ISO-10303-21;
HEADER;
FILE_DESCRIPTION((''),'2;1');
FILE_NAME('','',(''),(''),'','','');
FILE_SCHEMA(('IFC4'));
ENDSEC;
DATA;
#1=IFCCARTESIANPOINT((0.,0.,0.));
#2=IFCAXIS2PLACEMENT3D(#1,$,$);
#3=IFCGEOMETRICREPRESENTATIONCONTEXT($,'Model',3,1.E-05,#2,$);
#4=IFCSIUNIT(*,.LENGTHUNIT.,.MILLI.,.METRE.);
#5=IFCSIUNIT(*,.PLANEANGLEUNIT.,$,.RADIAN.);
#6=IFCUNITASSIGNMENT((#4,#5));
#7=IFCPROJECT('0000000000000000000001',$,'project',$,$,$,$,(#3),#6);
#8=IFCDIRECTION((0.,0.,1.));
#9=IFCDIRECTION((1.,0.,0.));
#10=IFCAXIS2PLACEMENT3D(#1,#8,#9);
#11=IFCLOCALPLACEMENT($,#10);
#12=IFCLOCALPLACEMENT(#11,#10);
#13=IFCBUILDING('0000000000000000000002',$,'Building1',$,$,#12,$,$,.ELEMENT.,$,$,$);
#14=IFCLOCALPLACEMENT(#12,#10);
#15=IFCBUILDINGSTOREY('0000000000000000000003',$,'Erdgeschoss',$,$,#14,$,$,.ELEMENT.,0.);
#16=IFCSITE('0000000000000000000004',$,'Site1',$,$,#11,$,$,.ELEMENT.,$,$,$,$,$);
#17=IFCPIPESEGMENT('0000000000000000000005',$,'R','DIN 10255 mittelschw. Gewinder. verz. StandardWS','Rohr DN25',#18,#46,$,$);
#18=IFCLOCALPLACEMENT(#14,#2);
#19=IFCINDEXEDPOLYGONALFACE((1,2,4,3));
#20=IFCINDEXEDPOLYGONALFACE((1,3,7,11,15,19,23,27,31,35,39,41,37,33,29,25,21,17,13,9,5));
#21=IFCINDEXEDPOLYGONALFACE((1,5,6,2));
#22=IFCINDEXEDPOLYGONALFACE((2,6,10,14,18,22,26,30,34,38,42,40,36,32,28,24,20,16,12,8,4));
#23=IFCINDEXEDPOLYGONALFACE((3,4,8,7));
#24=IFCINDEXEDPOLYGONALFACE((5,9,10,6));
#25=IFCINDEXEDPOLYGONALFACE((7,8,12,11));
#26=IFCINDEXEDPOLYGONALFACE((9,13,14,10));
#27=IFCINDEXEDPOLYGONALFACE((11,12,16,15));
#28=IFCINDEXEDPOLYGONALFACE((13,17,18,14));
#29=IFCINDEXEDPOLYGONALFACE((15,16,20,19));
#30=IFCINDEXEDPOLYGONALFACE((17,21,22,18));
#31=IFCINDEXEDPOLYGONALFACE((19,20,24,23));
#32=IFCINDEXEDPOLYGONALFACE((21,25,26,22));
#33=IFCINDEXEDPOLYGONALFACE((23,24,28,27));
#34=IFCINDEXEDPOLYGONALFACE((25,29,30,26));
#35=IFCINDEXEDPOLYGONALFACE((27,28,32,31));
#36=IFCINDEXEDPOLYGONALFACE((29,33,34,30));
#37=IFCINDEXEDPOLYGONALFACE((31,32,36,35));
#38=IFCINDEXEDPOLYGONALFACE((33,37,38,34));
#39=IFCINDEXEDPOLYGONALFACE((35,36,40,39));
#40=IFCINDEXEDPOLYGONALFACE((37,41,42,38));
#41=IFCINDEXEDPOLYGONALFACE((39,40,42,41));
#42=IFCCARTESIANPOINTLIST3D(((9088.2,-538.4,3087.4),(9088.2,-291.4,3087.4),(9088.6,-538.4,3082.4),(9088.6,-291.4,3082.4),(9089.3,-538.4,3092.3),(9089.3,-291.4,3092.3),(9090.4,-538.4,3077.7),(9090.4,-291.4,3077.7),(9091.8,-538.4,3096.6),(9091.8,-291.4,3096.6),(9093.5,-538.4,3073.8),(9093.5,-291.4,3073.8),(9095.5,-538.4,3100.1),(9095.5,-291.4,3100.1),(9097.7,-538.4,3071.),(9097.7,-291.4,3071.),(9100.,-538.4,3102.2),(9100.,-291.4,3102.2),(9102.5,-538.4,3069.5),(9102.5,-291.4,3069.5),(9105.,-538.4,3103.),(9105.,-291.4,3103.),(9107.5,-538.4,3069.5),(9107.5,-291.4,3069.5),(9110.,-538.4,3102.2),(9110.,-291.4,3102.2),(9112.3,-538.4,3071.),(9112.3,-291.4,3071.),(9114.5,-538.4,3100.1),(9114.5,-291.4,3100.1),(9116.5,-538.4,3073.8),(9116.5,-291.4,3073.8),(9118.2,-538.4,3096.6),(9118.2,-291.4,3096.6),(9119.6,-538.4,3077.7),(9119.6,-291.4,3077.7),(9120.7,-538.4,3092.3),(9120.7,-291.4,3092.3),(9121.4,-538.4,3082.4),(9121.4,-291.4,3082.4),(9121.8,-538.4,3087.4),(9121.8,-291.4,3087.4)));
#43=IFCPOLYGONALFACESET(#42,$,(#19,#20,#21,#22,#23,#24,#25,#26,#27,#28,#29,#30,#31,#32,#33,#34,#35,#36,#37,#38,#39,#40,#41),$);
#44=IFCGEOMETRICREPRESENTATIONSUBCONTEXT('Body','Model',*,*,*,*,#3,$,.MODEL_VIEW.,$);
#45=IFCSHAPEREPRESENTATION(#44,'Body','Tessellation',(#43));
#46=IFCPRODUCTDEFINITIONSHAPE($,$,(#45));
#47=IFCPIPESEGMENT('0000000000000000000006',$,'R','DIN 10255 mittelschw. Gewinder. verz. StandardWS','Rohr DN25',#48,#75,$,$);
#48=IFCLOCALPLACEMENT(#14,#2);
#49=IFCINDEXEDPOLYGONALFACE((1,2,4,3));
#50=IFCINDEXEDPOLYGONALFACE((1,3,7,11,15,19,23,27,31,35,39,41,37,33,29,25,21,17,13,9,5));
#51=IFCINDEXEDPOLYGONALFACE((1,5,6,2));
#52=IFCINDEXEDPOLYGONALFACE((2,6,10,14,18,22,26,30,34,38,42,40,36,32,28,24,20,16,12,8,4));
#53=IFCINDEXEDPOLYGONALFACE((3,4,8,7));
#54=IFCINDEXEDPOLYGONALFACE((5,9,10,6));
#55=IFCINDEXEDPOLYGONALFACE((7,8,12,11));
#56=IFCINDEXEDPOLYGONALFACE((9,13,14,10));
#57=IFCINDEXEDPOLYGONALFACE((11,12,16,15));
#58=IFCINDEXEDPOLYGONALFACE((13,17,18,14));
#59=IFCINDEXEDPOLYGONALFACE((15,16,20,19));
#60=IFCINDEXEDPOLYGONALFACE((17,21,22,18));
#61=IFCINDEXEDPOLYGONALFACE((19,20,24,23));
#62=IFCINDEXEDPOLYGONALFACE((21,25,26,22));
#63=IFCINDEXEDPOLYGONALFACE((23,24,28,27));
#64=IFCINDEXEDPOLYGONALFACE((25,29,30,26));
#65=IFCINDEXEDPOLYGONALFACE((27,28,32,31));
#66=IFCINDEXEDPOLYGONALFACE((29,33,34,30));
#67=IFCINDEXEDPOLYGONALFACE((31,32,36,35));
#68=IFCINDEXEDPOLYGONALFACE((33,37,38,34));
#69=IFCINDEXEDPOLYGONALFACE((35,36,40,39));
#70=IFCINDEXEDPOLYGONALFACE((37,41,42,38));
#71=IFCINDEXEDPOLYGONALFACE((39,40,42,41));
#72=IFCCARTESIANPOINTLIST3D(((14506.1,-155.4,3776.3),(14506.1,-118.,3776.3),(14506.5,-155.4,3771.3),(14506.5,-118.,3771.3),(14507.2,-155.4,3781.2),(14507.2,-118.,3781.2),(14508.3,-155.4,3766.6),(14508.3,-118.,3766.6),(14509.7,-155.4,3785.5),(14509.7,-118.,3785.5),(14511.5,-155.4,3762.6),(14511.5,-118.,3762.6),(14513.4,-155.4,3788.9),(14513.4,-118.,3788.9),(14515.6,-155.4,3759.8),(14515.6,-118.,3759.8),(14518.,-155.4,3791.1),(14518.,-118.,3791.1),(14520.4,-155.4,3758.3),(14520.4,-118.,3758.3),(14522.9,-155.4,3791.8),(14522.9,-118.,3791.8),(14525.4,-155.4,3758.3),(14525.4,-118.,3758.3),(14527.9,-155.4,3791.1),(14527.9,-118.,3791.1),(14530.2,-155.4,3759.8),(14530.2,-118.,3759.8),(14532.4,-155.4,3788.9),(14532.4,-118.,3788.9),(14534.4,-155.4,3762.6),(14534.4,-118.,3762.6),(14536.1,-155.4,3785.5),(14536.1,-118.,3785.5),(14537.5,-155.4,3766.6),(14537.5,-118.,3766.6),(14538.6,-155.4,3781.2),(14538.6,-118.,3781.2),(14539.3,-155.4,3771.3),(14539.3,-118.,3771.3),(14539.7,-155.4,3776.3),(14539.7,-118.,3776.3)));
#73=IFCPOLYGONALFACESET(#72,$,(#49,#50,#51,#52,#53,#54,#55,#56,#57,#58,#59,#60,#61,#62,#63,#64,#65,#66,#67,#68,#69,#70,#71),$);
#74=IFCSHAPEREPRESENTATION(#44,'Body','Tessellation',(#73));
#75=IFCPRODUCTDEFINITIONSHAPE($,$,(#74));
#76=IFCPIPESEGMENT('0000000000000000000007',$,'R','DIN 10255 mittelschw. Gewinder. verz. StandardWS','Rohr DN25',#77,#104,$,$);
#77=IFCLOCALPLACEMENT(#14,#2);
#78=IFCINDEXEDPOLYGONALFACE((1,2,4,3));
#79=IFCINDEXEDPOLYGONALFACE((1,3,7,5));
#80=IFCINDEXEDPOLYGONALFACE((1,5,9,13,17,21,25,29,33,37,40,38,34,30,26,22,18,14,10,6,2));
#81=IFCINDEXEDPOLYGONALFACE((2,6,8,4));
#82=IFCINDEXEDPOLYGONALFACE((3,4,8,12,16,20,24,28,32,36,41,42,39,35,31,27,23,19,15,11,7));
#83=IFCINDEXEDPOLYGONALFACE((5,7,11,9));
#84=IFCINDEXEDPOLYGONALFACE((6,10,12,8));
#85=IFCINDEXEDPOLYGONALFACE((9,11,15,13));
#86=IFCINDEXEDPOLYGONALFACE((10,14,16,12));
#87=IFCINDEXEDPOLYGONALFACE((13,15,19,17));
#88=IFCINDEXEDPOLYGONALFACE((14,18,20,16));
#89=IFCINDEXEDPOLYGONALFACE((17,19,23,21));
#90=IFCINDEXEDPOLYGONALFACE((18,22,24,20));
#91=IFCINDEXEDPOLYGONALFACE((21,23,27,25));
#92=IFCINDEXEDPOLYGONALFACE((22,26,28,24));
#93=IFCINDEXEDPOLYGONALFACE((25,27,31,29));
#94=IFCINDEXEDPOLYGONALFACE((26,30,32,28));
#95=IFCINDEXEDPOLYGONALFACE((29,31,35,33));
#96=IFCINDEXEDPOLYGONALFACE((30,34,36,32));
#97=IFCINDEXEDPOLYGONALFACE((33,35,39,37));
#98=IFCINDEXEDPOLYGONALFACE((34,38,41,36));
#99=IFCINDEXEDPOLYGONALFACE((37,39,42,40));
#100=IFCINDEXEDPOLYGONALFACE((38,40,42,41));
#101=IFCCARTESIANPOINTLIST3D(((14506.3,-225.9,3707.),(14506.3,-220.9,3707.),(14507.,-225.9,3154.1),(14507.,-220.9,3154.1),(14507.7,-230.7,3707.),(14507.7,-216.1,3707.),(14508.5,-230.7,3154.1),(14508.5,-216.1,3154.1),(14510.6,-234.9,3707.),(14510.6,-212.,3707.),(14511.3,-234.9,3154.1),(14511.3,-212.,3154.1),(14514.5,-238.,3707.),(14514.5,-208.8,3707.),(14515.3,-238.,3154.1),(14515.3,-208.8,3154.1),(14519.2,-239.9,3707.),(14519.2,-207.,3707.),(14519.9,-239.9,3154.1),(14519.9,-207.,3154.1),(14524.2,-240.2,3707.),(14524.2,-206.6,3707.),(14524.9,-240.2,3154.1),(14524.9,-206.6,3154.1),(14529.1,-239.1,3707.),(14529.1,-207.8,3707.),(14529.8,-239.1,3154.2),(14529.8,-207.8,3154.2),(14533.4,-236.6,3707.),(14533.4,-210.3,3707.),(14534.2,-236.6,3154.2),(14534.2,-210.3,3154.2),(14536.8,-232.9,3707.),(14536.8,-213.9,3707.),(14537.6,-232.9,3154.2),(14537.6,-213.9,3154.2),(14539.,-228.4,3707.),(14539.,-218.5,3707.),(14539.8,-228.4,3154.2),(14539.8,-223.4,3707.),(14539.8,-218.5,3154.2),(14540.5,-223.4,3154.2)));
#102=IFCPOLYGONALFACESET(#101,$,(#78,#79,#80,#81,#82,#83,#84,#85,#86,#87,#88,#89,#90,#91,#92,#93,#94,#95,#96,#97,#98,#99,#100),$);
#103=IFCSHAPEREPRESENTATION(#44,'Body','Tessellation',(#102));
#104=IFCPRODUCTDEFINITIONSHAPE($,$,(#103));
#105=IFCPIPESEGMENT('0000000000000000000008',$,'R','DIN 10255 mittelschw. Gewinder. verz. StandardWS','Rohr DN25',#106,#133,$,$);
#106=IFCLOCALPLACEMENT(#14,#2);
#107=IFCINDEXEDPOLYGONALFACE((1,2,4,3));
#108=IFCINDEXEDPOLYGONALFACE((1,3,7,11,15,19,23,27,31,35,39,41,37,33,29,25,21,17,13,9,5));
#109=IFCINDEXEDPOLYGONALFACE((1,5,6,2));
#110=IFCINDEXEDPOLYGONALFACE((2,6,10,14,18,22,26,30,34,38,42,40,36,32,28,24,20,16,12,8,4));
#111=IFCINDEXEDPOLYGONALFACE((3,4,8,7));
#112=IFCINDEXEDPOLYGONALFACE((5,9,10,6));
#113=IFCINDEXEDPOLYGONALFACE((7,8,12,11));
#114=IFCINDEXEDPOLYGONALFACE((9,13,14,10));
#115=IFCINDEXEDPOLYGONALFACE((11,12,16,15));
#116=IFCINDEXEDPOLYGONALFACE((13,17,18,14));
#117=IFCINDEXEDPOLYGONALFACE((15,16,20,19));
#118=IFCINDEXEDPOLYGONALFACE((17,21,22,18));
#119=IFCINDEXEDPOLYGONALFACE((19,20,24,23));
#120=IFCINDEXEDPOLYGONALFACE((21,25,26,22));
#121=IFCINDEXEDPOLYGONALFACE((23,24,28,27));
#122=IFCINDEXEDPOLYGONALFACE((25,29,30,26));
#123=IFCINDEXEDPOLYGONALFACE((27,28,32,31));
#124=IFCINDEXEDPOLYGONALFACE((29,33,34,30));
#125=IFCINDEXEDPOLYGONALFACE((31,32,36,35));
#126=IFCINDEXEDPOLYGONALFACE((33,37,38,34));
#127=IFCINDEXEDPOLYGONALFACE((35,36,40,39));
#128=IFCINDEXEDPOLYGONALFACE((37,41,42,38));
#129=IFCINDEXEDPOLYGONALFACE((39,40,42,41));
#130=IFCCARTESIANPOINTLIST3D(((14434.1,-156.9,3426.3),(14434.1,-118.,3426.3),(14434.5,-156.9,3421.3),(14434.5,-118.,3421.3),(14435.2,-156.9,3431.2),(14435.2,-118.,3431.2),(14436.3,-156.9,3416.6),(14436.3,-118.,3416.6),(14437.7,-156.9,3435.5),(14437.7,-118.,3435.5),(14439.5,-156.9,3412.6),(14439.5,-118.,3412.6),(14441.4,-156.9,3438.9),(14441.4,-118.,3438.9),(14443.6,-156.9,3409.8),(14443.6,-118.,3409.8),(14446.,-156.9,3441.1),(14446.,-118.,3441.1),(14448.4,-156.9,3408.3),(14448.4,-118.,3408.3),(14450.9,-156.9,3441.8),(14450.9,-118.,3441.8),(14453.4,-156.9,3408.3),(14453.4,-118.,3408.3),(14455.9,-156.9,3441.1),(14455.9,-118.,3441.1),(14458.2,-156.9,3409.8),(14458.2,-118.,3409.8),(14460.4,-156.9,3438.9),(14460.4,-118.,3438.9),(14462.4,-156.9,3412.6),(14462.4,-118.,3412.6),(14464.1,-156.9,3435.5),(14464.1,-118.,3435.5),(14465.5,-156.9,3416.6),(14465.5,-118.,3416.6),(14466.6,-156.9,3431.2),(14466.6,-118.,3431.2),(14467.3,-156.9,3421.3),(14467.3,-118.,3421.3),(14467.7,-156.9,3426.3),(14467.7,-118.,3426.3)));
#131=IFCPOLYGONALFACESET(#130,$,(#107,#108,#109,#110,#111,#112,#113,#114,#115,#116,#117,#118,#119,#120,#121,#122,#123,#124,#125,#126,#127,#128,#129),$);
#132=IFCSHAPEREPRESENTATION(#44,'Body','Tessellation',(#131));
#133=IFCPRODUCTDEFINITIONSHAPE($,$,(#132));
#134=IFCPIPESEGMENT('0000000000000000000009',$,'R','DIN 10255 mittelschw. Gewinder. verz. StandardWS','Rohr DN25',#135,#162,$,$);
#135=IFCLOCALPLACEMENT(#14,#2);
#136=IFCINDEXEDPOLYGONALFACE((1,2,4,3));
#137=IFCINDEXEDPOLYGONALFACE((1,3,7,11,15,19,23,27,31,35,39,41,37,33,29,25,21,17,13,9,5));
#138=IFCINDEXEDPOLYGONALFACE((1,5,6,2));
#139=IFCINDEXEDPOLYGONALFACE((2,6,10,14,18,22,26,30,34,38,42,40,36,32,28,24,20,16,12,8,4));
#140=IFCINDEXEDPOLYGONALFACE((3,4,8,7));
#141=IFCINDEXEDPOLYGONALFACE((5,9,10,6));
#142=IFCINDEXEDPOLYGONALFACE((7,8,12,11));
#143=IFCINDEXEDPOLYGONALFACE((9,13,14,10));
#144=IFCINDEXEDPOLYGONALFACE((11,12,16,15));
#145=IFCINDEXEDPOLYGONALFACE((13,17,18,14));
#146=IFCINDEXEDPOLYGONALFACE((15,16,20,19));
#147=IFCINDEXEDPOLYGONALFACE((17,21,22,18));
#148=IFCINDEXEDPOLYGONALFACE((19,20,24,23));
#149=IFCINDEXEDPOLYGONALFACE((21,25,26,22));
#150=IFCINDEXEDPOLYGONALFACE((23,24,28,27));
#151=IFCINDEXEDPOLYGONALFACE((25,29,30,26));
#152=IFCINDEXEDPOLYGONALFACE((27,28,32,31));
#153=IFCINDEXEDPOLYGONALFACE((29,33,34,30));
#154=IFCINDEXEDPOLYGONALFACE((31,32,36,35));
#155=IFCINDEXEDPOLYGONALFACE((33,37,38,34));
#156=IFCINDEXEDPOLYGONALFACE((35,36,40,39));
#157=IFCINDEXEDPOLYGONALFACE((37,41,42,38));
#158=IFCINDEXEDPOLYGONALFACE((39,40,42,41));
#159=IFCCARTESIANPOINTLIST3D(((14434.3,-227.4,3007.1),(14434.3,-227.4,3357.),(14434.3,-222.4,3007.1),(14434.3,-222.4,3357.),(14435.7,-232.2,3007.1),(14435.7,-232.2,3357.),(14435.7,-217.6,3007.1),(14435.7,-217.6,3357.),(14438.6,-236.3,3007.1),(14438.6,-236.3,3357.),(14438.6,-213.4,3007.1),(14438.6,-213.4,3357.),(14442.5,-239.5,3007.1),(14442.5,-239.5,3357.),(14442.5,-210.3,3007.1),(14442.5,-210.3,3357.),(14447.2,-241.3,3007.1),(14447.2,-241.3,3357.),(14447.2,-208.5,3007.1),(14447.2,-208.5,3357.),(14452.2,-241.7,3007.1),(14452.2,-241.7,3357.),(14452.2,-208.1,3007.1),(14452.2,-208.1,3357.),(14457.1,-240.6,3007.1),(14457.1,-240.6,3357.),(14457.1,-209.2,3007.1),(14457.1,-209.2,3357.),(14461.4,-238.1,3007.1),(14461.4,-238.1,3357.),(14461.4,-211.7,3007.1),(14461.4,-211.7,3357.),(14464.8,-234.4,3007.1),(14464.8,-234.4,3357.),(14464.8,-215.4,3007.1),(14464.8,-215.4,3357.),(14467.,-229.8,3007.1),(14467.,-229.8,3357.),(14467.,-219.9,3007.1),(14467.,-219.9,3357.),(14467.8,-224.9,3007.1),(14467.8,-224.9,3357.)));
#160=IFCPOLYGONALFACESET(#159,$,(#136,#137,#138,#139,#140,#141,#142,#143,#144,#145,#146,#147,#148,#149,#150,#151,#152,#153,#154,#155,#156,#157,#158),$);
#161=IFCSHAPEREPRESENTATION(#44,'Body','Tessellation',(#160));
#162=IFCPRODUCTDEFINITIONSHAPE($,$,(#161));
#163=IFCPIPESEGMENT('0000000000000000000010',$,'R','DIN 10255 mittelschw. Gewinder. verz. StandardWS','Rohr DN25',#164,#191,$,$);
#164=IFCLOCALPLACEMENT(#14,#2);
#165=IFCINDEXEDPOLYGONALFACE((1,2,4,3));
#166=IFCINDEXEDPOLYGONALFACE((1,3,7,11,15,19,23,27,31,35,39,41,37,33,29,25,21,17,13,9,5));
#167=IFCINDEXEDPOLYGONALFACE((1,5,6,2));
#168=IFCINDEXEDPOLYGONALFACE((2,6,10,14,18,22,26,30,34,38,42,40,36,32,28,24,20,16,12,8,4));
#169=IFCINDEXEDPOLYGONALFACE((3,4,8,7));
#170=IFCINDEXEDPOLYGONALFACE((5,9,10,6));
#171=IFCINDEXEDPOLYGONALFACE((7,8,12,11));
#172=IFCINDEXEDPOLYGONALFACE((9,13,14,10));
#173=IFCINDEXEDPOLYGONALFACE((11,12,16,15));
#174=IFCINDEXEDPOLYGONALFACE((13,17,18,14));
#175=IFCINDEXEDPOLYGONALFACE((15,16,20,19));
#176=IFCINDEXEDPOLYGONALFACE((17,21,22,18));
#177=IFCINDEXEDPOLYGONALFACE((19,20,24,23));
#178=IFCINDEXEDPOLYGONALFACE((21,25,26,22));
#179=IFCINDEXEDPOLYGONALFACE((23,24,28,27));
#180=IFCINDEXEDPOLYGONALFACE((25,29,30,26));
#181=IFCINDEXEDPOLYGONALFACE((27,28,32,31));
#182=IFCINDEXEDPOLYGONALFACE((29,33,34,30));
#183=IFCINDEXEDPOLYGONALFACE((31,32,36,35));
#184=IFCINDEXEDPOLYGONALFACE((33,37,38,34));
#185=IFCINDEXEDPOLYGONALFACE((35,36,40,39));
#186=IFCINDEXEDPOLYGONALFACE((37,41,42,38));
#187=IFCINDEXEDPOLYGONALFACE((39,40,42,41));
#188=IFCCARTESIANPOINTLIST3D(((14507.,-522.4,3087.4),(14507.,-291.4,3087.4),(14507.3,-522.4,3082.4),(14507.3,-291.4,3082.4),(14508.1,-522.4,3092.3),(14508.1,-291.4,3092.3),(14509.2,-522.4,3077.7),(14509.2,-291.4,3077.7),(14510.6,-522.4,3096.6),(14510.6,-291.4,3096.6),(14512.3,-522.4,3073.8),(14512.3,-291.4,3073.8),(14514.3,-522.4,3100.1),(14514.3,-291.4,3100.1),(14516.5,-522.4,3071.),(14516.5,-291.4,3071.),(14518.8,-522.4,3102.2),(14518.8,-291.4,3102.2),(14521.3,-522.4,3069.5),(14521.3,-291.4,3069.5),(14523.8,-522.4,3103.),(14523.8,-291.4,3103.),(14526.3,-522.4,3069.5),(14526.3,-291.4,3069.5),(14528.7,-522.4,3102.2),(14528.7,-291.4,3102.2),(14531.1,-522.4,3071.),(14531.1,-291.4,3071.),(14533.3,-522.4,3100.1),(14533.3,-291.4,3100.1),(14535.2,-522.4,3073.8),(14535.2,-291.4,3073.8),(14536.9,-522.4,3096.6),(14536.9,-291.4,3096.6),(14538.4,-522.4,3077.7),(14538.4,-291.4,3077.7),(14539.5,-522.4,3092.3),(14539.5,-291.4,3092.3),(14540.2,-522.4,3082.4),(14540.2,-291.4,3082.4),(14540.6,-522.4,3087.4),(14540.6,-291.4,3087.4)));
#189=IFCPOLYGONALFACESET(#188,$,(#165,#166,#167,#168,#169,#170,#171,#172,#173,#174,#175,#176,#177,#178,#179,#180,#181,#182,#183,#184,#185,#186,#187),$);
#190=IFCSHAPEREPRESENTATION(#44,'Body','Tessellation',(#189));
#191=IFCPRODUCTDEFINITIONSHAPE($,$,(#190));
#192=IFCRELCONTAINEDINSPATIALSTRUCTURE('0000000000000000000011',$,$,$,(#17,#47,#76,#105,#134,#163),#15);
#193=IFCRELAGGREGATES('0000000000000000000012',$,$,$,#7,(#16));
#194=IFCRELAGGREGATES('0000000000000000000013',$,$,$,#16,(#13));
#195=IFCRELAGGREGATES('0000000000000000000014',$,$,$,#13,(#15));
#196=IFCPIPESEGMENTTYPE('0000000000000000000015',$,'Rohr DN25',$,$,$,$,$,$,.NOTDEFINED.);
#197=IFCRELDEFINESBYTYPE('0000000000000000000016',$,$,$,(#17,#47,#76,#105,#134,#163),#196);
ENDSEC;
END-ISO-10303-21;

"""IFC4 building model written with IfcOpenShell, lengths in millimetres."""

from ifc_helpers import new_model, si_unit, frame, origin, origin_with_axes, origin_2d_with_axis, place, context, subcontext, project, spatial, circle, extrude, type_object, element, save


model = new_model("IFC4")

# Units and contexts
model_context = context("Model", 3, precision=1e-05, world=origin())
body_context = subcontext(model_context, "Body", "Model", "MODEL_VIEW")
ifc_project = project(units=[si_unit("LENGTHUNIT", "METRE", prefix="MILLI"), si_unit("PLANEANGLEUNIT", "RADIAN")], contexts=[model_context])

# Site, building, storey
site_placement = place(None, origin_with_axes())
site = spatial("IfcSite", under=ifc_project, at=site_placement, Name="Site1", CompositionType="ELEMENT")
building_placement = place(site_placement, origin_with_axes())
building = spatial("IfcBuilding", under=site, at=building_placement, Name="Building1", CompositionType="ELEMENT")
storey_placement = place(building_placement, origin_with_axes())
storey = spatial("IfcBuildingStorey", under=building, at=storey_placement, Name="Erdgeschoss", CompositionType="ELEMENT", Elevation=0.0)

# Pipe segments
pipe_segment_type_1 = type_object("IfcPipeSegmentType", Name="Rohr DN25", PredefinedType="NOTDEFINED")
pipe_segment_1_placement = place(storey_placement, frame((9104.8, -414.9, 3086.1), z_axis=(0.0, 0.0, 1.0), x_axis=(1.0, 0.0, 0.0)))
element("IfcPipeSegment", 1, at=pipe_segment_1_placement, inside=storey, type_object=pipe_segment_type_1, Name="R", Description="DIN 10255 mittelschw. Gewinder. verz. StandardWS", ObjectType="Rohr DN25", context=body_context, shape_type="SolidModel", body=[
    extrude(circle(Radius=16.9, at=origin_2d_with_axis()), frame((0.1, -123.5, 0.0), z_axis=(0.0, 1.0, 0.0), x_axis=(0.0, 0.0, 1.0)), (0.0, 0.0, 1.0), 247.0),
])
pipe_segment_2_placement = place(storey_placement, frame((14523.1, -136.7, 3775.0), z_axis=(0.0, 0.0, 1.0), x_axis=(1.0, 0.0, 0.0)))
element("IfcPipeSegment", 2, at=pipe_segment_2_placement, inside=storey, type_object=pipe_segment_type_1, Name="R", Description="DIN 10255 mittelschw. Gewinder. verz. StandardWS", ObjectType="Rohr DN25", context=body_context, shape_type="SolidModel", body=[
    extrude(circle(Radius=16.9, at=origin_2d_with_axis()), frame((-0.1, 18.7, 0.0), z_axis=(0.0, -1.0, 0.0), x_axis=(0.0, 0.0, 1.0)), (0.0, 0.0, 1.0), 37.4),
])
pipe_segment_3_placement = place(storey_placement, frame((14523.3, -223.3, 3430.6), z_axis=(0.0, 0.0, 1.0), x_axis=(1.0, 0.0, 0.0)))
element("IfcPipeSegment", 3, at=pipe_segment_3_placement, inside=storey, type_object=pipe_segment_type_1, Name="R", Description="DIN 10255 mittelschw. Gewinder. verz. StandardWS", ObjectType="Rohr DN25", context=body_context, shape_type="SolidModel", body=[
    extrude(circle(Radius=16.9, at=origin_2d_with_axis()), frame((-0.4, -0.2, 276.4), z_axis=(0.001364, 0.0, -0.999999), x_axis=(1.0, 0.0, 0.0)), (0.0, 0.0, 1.0), 552.9),
])
pipe_segment_4_placement = place(storey_placement, frame((14451.1, -137.4, 3425.0), z_axis=(0.0, 0.0, 1.0), x_axis=(1.0, 0.0, 0.0)))
element("IfcPipeSegment", 4, at=pipe_segment_4_placement, inside=storey, type_object=pipe_segment_type_1, Name="R", Description="DIN 10255 mittelschw. Gewinder. verz. StandardWS", ObjectType="Rohr DN25", context=body_context, shape_type="SolidModel", body=[
    extrude(circle(Radius=16.9, at=origin_2d_with_axis()), frame((-0.1, 19.4, 0.0), z_axis=(0.0, -1.0, 0.0), x_axis=(0.0, 0.0, 1.0)), (0.0, 0.0, 1.0), 38.9),
])
pipe_segment_5_placement = place(storey_placement, frame((14450.9, -224.7, 3182.1), z_axis=(0.0, 0.0, 1.0), x_axis=(1.0, 0.0, 0.0)))
element("IfcPipeSegment", 5, at=pipe_segment_5_placement, inside=storey, type_object=pipe_segment_type_1, Name="R", Description="DIN 10255 mittelschw. Gewinder. verz. StandardWS", ObjectType="Rohr DN25", context=body_context, shape_type="SolidModel", body=[
    extrude(circle(Radius=16.9, at=origin_2d_with_axis()), frame((0.0, -0.2, 174.9), z_axis=(0.0, 0.0, -1.0), x_axis=(1.0, 0.0, 0.0)), (0.0, 0.0, 1.0), 349.9),
])
pipe_segment_6_placement = place(storey_placement, frame((14523.6, -406.9, 3086.1), z_axis=(0.0, 0.0, 1.0), x_axis=(1.0, 0.0, 0.0)))
element("IfcPipeSegment", 6, at=pipe_segment_6_placement, inside=storey, type_object=pipe_segment_type_1, Name="R", Description="DIN 10255 mittelschw. Gewinder. verz. StandardWS", ObjectType="Rohr DN25", context=body_context, shape_type="SolidModel", body=[
    extrude(circle(Radius=16.9, at=origin_2d_with_axis()), frame((0.1, -115.5, 0.0), z_axis=(0.000001, 1.0, 0.0), x_axis=(0.0, 0.0, 1.0)), (0.0, 0.0, 1.0), 231.0),
])

save(model, "model.ifc")
